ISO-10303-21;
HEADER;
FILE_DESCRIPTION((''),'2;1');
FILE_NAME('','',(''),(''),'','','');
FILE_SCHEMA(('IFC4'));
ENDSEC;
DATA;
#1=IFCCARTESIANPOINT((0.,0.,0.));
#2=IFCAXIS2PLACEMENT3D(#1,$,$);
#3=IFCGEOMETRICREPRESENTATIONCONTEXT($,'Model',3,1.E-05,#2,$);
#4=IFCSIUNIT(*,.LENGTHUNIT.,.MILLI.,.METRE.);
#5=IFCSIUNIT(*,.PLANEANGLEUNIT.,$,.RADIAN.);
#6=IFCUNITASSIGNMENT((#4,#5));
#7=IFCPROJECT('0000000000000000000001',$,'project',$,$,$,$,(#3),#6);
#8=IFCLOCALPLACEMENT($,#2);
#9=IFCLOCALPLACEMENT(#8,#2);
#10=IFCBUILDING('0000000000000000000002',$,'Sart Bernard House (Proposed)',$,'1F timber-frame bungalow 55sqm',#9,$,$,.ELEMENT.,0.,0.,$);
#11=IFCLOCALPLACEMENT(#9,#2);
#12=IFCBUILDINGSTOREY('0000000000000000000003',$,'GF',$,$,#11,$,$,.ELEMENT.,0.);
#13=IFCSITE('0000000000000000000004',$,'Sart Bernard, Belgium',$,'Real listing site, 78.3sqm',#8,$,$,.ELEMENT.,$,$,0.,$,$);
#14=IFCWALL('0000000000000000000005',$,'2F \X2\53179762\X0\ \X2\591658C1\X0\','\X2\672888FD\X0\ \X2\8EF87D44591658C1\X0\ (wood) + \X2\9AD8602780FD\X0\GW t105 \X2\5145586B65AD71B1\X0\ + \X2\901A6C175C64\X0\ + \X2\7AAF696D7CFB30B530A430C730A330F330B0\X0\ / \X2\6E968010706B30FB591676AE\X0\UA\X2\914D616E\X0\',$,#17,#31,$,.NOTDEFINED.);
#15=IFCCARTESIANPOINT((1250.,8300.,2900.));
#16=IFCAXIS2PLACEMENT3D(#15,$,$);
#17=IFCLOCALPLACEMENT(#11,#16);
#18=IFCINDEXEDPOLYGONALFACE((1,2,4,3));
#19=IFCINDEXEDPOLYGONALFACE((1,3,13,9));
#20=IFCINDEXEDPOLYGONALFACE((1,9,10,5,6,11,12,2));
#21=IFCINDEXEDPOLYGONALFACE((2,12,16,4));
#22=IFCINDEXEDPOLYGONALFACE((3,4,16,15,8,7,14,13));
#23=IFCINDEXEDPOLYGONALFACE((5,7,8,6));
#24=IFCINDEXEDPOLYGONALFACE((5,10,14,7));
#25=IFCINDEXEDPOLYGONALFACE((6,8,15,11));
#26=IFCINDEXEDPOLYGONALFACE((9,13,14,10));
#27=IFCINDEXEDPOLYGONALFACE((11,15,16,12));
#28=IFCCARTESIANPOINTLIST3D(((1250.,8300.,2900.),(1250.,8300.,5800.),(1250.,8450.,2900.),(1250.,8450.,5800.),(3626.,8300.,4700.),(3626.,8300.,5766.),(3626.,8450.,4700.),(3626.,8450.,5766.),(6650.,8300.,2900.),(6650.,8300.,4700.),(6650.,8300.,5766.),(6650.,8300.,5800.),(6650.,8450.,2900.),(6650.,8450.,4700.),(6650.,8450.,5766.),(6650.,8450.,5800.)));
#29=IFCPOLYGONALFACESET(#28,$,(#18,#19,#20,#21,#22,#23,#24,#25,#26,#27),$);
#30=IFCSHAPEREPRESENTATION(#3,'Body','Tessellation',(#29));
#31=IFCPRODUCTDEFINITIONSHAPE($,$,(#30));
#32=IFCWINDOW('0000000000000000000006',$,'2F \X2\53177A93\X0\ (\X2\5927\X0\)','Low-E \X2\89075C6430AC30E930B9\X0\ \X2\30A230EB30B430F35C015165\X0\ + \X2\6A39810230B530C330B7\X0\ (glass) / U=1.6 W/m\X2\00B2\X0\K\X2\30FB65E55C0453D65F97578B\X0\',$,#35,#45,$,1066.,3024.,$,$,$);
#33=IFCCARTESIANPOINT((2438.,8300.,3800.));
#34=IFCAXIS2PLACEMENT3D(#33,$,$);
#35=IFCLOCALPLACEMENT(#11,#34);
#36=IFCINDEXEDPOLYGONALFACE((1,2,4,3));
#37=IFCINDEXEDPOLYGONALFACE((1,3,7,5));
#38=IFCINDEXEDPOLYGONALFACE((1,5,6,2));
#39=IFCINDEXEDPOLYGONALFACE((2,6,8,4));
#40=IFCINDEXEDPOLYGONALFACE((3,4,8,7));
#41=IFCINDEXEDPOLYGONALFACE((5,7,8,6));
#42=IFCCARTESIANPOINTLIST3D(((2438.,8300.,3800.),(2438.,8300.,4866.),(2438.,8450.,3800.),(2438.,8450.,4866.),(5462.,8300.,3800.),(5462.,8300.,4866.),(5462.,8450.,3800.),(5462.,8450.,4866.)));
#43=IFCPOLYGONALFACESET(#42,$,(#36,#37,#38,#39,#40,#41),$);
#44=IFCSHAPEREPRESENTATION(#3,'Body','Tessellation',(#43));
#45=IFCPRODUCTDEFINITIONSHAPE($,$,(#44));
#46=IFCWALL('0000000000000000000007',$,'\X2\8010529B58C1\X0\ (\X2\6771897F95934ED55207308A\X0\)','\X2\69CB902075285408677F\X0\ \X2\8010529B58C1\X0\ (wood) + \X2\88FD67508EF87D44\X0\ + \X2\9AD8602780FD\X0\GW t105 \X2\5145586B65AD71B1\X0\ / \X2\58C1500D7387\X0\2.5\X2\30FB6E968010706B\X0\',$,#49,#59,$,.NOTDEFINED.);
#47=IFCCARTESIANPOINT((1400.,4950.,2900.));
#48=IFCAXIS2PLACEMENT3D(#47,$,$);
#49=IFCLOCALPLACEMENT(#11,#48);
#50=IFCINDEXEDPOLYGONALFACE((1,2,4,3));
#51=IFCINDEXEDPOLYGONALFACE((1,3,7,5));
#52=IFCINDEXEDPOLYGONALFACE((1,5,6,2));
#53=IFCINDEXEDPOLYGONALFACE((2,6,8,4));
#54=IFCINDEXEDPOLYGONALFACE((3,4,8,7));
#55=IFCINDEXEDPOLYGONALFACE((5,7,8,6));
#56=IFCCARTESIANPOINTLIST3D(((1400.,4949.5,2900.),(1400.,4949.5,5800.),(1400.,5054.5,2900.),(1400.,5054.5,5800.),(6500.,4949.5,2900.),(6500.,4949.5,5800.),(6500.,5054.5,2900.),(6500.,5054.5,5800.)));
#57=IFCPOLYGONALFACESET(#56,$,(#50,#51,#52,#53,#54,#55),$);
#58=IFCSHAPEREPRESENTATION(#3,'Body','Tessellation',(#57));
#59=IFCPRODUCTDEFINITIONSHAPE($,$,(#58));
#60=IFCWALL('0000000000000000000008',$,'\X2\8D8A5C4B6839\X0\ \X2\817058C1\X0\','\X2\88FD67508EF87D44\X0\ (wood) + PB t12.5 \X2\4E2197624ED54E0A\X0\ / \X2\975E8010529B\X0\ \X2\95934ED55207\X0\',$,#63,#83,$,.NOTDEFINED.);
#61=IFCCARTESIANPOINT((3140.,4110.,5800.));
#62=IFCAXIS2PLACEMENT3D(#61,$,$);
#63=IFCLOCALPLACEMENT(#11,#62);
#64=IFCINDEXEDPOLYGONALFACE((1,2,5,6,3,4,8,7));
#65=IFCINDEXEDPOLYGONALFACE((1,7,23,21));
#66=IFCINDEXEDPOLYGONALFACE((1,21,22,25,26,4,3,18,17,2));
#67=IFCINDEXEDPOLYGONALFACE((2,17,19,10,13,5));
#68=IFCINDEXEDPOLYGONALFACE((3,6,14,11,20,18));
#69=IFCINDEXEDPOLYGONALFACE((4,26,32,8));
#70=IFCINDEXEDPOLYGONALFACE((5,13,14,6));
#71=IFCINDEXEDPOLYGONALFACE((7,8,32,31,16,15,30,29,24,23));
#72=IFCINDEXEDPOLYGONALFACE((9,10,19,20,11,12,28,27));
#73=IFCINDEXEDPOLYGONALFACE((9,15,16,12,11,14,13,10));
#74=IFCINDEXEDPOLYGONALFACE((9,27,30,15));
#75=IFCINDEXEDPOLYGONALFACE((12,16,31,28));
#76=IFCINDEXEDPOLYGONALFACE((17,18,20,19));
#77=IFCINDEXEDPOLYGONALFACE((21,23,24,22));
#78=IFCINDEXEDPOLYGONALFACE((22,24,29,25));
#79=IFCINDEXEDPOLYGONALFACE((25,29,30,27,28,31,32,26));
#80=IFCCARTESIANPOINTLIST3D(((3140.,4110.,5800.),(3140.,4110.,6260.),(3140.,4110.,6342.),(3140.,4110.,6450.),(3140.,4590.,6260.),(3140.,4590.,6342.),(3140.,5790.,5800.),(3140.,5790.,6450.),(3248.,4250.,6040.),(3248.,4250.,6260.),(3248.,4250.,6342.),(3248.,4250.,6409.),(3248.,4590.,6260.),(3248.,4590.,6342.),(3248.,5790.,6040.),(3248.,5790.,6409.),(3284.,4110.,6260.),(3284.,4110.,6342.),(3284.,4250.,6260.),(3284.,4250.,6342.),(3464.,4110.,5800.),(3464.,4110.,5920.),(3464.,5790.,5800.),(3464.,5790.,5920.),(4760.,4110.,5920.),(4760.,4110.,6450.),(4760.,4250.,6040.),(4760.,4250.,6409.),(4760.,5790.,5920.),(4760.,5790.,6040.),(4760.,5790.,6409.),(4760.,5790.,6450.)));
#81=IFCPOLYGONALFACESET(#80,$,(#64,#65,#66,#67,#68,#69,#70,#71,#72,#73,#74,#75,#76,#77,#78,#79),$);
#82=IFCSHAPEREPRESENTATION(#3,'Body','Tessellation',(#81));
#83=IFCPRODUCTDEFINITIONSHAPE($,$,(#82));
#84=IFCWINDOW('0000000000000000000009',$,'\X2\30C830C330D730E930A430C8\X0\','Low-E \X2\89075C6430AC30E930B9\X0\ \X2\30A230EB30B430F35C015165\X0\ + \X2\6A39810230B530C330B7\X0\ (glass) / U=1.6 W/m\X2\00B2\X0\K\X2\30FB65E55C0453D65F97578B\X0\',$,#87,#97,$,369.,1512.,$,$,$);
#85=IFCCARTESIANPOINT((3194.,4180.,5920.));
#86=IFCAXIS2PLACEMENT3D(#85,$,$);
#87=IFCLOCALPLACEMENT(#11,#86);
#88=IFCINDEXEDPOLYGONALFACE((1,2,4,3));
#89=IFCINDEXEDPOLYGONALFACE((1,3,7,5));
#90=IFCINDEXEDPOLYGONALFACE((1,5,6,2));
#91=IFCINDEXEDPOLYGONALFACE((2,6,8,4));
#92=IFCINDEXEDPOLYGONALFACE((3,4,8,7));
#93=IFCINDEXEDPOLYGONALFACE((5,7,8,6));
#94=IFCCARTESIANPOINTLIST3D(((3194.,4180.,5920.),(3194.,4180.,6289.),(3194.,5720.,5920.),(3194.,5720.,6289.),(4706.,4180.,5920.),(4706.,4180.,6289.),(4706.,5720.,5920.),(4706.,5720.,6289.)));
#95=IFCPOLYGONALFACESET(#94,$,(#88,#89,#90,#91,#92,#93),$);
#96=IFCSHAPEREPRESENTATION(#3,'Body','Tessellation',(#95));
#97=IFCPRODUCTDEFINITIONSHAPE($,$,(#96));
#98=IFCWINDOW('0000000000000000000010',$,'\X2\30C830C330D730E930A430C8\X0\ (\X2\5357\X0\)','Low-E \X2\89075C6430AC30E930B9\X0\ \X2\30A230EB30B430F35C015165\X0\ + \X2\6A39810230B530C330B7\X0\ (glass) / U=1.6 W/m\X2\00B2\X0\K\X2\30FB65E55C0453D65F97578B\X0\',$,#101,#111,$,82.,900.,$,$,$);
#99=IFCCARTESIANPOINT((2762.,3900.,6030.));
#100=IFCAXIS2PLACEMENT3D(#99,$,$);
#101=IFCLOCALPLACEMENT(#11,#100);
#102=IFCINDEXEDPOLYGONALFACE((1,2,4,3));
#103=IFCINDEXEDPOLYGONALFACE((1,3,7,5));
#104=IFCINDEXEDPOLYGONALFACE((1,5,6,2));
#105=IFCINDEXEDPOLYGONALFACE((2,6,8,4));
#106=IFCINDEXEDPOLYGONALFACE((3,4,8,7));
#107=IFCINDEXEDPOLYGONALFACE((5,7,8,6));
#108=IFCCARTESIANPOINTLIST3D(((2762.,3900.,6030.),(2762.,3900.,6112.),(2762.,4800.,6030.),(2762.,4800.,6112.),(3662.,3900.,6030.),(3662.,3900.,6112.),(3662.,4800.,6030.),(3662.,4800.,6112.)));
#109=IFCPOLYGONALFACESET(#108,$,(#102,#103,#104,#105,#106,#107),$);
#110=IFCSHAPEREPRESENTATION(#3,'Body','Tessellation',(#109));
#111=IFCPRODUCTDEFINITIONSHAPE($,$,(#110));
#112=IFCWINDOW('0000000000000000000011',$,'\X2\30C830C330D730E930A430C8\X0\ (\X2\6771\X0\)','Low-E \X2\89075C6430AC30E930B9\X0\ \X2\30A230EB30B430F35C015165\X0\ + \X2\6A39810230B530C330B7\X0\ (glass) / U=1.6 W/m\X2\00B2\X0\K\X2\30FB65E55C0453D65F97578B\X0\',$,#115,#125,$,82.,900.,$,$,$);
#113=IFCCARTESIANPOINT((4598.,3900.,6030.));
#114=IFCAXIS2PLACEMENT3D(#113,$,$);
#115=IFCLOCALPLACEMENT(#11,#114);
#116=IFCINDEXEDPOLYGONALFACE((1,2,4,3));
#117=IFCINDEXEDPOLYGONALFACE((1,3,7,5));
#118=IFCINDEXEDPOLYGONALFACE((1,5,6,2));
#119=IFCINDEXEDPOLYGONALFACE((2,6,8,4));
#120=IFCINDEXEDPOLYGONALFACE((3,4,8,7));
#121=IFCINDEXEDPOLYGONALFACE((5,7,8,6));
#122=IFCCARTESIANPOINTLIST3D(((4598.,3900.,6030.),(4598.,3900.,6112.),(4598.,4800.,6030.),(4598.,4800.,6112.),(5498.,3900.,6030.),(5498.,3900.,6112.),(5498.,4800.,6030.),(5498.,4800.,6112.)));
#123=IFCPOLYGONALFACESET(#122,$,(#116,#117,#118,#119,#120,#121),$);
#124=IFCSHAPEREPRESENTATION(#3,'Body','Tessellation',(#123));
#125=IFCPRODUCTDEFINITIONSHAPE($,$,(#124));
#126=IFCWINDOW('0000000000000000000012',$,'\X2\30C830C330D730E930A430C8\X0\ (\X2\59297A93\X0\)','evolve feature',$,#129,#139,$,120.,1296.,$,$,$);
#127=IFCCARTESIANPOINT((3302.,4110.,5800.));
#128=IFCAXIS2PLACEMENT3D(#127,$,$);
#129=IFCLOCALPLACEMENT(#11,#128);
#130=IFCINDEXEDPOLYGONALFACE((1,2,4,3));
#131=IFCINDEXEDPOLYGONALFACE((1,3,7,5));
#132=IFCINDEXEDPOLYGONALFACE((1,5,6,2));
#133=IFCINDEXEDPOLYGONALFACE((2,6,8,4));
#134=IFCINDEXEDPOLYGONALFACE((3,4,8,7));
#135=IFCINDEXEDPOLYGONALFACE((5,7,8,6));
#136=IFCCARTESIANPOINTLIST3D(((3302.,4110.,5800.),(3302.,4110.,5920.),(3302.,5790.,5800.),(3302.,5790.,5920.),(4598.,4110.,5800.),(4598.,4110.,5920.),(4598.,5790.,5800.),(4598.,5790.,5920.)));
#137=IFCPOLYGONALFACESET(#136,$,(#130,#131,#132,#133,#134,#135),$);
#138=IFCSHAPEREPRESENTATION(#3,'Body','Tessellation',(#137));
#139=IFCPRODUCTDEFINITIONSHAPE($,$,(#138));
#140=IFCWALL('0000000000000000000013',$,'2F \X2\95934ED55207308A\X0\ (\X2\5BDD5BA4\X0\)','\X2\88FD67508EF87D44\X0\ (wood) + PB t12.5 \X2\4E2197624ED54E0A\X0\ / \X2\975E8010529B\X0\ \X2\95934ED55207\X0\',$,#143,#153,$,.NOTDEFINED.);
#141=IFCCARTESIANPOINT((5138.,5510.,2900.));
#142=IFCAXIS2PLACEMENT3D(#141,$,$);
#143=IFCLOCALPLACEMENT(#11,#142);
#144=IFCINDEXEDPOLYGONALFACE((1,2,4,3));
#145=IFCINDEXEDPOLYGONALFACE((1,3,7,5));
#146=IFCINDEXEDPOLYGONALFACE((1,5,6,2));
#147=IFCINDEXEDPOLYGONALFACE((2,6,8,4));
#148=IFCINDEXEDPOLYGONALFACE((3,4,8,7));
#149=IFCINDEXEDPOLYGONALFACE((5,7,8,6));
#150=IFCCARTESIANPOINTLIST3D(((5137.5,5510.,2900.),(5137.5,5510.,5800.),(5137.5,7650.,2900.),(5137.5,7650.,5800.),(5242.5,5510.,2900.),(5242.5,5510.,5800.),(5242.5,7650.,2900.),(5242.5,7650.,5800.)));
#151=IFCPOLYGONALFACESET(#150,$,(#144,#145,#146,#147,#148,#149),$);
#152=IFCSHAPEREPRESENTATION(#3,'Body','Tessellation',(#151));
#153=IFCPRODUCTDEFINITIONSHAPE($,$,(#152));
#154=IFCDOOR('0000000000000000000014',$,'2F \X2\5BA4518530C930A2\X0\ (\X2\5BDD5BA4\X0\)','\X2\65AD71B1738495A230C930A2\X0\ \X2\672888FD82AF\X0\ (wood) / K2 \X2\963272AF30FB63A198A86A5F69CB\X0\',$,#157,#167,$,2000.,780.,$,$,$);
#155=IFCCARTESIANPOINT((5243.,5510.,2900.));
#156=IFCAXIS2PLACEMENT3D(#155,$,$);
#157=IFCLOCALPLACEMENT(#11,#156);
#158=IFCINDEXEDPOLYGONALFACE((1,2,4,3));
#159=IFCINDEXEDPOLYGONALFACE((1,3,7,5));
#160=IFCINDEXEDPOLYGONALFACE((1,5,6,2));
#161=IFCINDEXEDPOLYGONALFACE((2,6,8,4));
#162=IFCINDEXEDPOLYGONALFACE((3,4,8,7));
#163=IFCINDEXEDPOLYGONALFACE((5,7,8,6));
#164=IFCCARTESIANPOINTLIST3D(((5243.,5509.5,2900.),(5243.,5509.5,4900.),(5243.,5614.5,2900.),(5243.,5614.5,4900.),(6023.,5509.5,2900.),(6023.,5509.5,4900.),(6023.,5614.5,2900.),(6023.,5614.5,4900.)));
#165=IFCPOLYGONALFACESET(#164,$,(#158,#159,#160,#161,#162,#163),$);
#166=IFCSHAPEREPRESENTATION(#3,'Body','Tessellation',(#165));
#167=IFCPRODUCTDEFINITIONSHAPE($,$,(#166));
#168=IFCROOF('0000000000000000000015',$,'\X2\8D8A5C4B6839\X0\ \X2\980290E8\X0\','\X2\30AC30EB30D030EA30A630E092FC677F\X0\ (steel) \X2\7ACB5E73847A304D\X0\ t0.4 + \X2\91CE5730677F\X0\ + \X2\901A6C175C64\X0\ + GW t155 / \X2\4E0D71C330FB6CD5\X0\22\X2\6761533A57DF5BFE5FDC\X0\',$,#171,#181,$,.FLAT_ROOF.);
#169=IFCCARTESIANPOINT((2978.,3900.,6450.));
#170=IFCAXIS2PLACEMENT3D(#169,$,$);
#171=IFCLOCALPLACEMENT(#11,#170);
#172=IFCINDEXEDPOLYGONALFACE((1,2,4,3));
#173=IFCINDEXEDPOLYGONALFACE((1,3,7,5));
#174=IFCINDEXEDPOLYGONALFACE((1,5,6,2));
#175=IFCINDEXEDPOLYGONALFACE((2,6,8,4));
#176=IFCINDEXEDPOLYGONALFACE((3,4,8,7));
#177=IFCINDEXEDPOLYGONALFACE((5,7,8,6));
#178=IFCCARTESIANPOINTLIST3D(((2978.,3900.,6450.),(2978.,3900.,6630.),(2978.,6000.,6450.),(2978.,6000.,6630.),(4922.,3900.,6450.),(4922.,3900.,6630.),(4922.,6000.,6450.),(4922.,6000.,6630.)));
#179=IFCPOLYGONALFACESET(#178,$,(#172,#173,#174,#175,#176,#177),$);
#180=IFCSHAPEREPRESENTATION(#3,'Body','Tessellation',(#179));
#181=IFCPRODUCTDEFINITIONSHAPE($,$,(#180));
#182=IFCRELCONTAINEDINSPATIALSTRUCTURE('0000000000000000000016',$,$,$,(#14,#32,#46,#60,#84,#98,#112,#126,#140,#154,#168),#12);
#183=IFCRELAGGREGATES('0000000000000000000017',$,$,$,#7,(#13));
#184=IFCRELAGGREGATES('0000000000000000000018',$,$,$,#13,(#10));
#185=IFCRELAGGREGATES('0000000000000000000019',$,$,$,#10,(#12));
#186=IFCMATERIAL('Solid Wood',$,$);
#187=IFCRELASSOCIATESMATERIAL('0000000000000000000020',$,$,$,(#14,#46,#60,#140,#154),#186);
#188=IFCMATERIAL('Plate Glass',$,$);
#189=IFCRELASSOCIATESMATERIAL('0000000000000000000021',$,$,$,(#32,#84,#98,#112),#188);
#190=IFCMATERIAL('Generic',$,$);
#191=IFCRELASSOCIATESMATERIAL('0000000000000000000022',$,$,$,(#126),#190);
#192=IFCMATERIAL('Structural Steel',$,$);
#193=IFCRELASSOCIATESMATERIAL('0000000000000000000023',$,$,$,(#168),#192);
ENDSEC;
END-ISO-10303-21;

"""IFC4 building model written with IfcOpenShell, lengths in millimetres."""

from ifc_helpers import new_model, si_unit, frame, frame_2d, origin, place, context, project, spatial, rectangle, extrude, material, element, fill, save


model = new_model("IFC4")

# Units and contexts
model_context = context("Model", 3, precision=1e-05, world=origin())
ifc_project = project(units=[si_unit("LENGTHUNIT", "METRE", prefix="MILLI"), si_unit("PLANEANGLEUNIT", "RADIAN")], contexts=[model_context])

# Site, building, storey
site_placement = place(None, origin())
site = spatial("IfcSite", under=ifc_project, at=site_placement, Name="Sart Bernard, Belgium", ObjectType="Real listing site, 78.3sqm", CompositionType="ELEMENT", RefElevation=0.0)
building_placement = place(site_placement, origin())
building = spatial("IfcBuilding", under=site, at=building_placement, Name="Sart Bernard House (Proposed)", ObjectType="1F timber-frame bungalow 55sqm", CompositionType="ELEMENT", ElevationOfRefHeight=0.0, ElevationOfTerrain=0.0)
storey_placement = place(building_placement, origin())
storey = spatial("IfcBuildingStorey", under=building, at=storey_placement, Name="GF", CompositionType="ELEMENT", Elevation=0.0)

# Wall, opening, window
ifc_material_1 = material(Name="Solid Wood")
wall_1_placement = place(storey_placement, frame((1250.0, 8300.0, 2900.0)))
wall_1 = element("IfcWall", 1, at=wall_1_placement, inside=storey, material=ifc_material_1, Name="2F 北面 外壁", Description="木製 軸組外壁 (wood) + 高性能GW t105 充填断熱 + 通気層 + 窯業系サイディング / 準耐火・外皮UA配慮", PredefinedType="NOTDEFINED", context=model_context, shape_type="SweptSolid", body=[
    extrude(rectangle(XDim=5400.0, YDim=150.0, at=frame_2d((2700.0, 75.0))), frame((1250.0, 8300.0, 2900.0)), (0.0, 0.0, 1.0), 2900.0),
])
opening_1_placement = place(storey_placement, frame((2438.0, 8300.0, 3800.0)))
opening_1 = element("IfcOpeningElement", 2, at=opening_1_placement, cuts=wall_1, PredefinedType="NOTDEFINED", context=model_context, shape_type="SweptSolid", body=[
    extrude(rectangle(XDim=3024.0, YDim=150.0, at=frame_2d((1512.0, 75.0))), frame((2438.0, 8300.0, 3800.0)), (0.0, 0.0, 1.0), 1066.0),
])
ifc_material_2 = material(Name="Plate Glass")
window_1_placement = place(storey_placement, frame((2438.0, 8300.0, 3800.0)))
window_1 = element("IfcWindow", 3, at=window_1_placement, inside=storey, material=ifc_material_2, Name="2F 北窓 (大)", Description="Low-E 複層ガラス アルゴン封入 + 樹脂サッシ (glass) / U=1.6 W/m²K・日射取得型", OverallHeight=1066.0, OverallWidth=3024.0, context=model_context, shape_type="SweptSolid", body=[
    extrude(rectangle(XDim=3024.0, YDim=150.0, at=frame_2d((1512.0, 75.0))), frame((2438.0, 8300.0, 3800.0)), (0.0, 0.0, 1.0), 1066.0),
])
fill(opening_1, window_1)

# Wall
wall_2_placement = place(storey_placement, frame((1400.0, 4950.0, 2900.0)))
element("IfcWall", 4, at=wall_2_placement, inside=storey, material=ifc_material_1, Name="耐力壁 (東西間仕切り)", Description="構造用合板 耐力壁 (wood) + 製材軸組 + 高性能GW t105 充填断熱 / 壁倍率2.5・準耐火", PredefinedType="NOTDEFINED", context=model_context, shape_type="SweptSolid", body=[
    extrude(rectangle(XDim=5100.0, YDim=105.0, at=frame_2d((2550.0, 52.0))), frame((1400.0, 4950.0, 2900.0)), (0.0, 0.0, 1.0), 2900.0),
])

# Wall, openings, windows
wall_3_placement = place(storey_placement, frame((3140.0, 4110.0, 5800.0)))
wall_3 = element("IfcWall", 5, at=wall_3_placement, inside=storey, material=ifc_material_1, Name="越屋根 腰壁", Description="製材軸組 (wood) + PB t12.5 両面仕上 / 非耐力 間仕切", PredefinedType="NOTDEFINED", context=model_context, shape_type="SweptSolid", body=[
    extrude(rectangle(XDim=1620.0, YDim=1680.0, at=frame_2d((810.0, 840.0))), frame((3140.0, 4110.0, 5800.0)), (0.0, 0.0, 1.0), 650.0),
])
opening_2_placement = place(storey_placement, frame((3194.0, 4180.0, 5920.0)))
opening_2 = element("IfcOpeningElement", 6, at=opening_2_placement, cuts=wall_3, PredefinedType="NOTDEFINED", context=model_context, shape_type="SweptSolid", body=[
    extrude(rectangle(XDim=1512.0, YDim=1540.0, at=frame_2d((756.0, 770.0))), frame((3194.0, 4180.0, 5920.0)), (0.0, 0.0, 1.0), 369.0),
])
opening_3_placement = place(storey_placement, frame((2762.0, 3900.0, 6030.0)))
opening_3 = element("IfcOpeningElement", 7, at=opening_3_placement, cuts=wall_3, PredefinedType="NOTDEFINED", context=model_context, shape_type="SweptSolid", body=[
    extrude(rectangle(XDim=900.0, YDim=900.0, at=frame_2d((450.0, 450.0))), frame((2762.0, 3900.0, 6030.0)), (0.0, 0.0, 1.0), 82.0),
])
opening_4_placement = place(storey_placement, frame((4598.0, 3900.0, 6030.0)))
opening_4 = element("IfcOpeningElement", 8, at=opening_4_placement, cuts=wall_3, PredefinedType="NOTDEFINED", context=model_context, shape_type="SweptSolid", body=[
    extrude(rectangle(XDim=900.0, YDim=900.0, at=frame_2d((450.0, 450.0))), frame((4598.0, 3900.0, 6030.0)), (0.0, 0.0, 1.0), 82.0),
])
opening_5_placement = place(storey_placement, frame((3302.0, 4110.0, 5800.0)))
opening_5 = element("IfcOpeningElement", 9, at=opening_5_placement, cuts=wall_3, PredefinedType="NOTDEFINED", context=model_context, shape_type="SweptSolid", body=[
    extrude(rectangle(XDim=1296.0, YDim=1680.0, at=frame_2d((648.0, 840.0))), frame((3302.0, 4110.0, 5800.0)), (0.0, 0.0, 1.0), 120.0),
])
window_2_placement = place(storey_placement, frame((3194.0, 4180.0, 5920.0)))
window_2 = element("IfcWindow", 10, at=window_2_placement, inside=storey, material=ifc_material_2, Name="トップライト", Description="Low-E 複層ガラス アルゴン封入 + 樹脂サッシ (glass) / U=1.6 W/m²K・日射取得型", OverallHeight=369.0, OverallWidth=1512.0, context=model_context, shape_type="SweptSolid", body=[
    extrude(rectangle(XDim=1512.0, YDim=1540.0, at=frame_2d((756.0, 770.0))), frame((3194.0, 4180.0, 5920.0)), (0.0, 0.0, 1.0), 369.0),
])
fill(opening_2, window_2)
window_3_placement = place(storey_placement, frame((2762.0, 3900.0, 6030.0)))
window_3 = element("IfcWindow", 11, at=window_3_placement, inside=storey, material=ifc_material_2, Name="トップライト (南)", Description="Low-E 複層ガラス アルゴン封入 + 樹脂サッシ (glass) / U=1.6 W/m²K・日射取得型", OverallHeight=82.0, OverallWidth=900.0, context=model_context, shape_type="SweptSolid", body=[
    extrude(rectangle(XDim=900.0, YDim=900.0, at=frame_2d((450.0, 450.0))), frame((2762.0, 3900.0, 6030.0)), (0.0, 0.0, 1.0), 82.0),
])
fill(opening_3, window_3)
window_4_placement = place(storey_placement, frame((4598.0, 3900.0, 6030.0)))
window_4 = element("IfcWindow", 12, at=window_4_placement, inside=storey, material=ifc_material_2, Name="トップライト (東)", Description="Low-E 複層ガラス アルゴン封入 + 樹脂サッシ (glass) / U=1.6 W/m²K・日射取得型", OverallHeight=82.0, OverallWidth=900.0, context=model_context, shape_type="SweptSolid", body=[
    extrude(rectangle(XDim=900.0, YDim=900.0, at=frame_2d((450.0, 450.0))), frame((4598.0, 3900.0, 6030.0)), (0.0, 0.0, 1.0), 82.0),
])
fill(opening_4, window_4)
ifc_material_3 = material(Name="Generic")
window_5_placement = place(storey_placement, frame((3302.0, 4110.0, 5800.0)))
window_5 = element("IfcWindow", 13, at=window_5_placement, inside=storey, material=ifc_material_3, Name="トップライト (天窓)", Description="evolve feature", OverallHeight=120.0, OverallWidth=1296.0, context=model_context, shape_type="SweptSolid", body=[
    extrude(rectangle(XDim=1296.0, YDim=1680.0, at=frame_2d((648.0, 840.0))), frame((3302.0, 4110.0, 5800.0)), (0.0, 0.0, 1.0), 120.0),
])
fill(opening_5, window_5)

# Wall
wall_4_placement = place(storey_placement, frame((5138.0, 5510.0, 2900.0)))
element("IfcWall", 14, at=wall_4_placement, inside=storey, material=ifc_material_1, Name="2F 間仕切り (寝室)", Description="製材軸組 (wood) + PB t12.5 両面仕上 / 非耐力 間仕切", PredefinedType="NOTDEFINED", context=model_context, shape_type="SweptSolid", body=[
    extrude(rectangle(XDim=105.0, YDim=2140.0, at=frame_2d((52.0, 1070.0))), frame((5138.0, 5510.0, 2900.0)), (0.0, 0.0, 1.0), 2900.0),
])

# Door
door_placement = place(storey_placement, frame((5243.0, 5510.0, 2900.0)))
element("IfcDoor", 15, at=door_placement, inside=storey, material=ifc_material_1, Name="2F 室内ドア (寝室)", Description="断熱玄関ドア 木製芯 (wood) / K2 防犯・採風機構", OverallHeight=2000.0, OverallWidth=780.0, context=model_context, shape_type="SweptSolid", body=[
    extrude(rectangle(XDim=780.0, YDim=105.0, at=frame_2d((390.0, 52.0))), frame((5243.0, 5510.0, 2900.0)), (0.0, 0.0, 1.0), 2000.0),
])

# Roof
ifc_material_4 = material(Name="Structural Steel")
roof_placement = place(storey_placement, frame((2978.0, 3900.0, 6450.0)))
element("IfcRoof", 16, at=roof_placement, inside=storey, material=ifc_material_4, Name="越屋根 頂部", Description="ガルバリウム鋼板 (steel) 立平葺き t0.4 + 野地板 + 通気層 + GW t155 / 不燃・法22条区域対応", PredefinedType="FLAT_ROOF", context=model_context, shape_type="SweptSolid", body=[
    extrude(rectangle(XDim=1944.0, YDim=2100.0, at=frame_2d((972.0, 1050.0))), frame((2978.0, 3900.0, 6450.0)), (0.0, 0.0, 1.0), 180.0),
])

save(model, "model.ifc")
